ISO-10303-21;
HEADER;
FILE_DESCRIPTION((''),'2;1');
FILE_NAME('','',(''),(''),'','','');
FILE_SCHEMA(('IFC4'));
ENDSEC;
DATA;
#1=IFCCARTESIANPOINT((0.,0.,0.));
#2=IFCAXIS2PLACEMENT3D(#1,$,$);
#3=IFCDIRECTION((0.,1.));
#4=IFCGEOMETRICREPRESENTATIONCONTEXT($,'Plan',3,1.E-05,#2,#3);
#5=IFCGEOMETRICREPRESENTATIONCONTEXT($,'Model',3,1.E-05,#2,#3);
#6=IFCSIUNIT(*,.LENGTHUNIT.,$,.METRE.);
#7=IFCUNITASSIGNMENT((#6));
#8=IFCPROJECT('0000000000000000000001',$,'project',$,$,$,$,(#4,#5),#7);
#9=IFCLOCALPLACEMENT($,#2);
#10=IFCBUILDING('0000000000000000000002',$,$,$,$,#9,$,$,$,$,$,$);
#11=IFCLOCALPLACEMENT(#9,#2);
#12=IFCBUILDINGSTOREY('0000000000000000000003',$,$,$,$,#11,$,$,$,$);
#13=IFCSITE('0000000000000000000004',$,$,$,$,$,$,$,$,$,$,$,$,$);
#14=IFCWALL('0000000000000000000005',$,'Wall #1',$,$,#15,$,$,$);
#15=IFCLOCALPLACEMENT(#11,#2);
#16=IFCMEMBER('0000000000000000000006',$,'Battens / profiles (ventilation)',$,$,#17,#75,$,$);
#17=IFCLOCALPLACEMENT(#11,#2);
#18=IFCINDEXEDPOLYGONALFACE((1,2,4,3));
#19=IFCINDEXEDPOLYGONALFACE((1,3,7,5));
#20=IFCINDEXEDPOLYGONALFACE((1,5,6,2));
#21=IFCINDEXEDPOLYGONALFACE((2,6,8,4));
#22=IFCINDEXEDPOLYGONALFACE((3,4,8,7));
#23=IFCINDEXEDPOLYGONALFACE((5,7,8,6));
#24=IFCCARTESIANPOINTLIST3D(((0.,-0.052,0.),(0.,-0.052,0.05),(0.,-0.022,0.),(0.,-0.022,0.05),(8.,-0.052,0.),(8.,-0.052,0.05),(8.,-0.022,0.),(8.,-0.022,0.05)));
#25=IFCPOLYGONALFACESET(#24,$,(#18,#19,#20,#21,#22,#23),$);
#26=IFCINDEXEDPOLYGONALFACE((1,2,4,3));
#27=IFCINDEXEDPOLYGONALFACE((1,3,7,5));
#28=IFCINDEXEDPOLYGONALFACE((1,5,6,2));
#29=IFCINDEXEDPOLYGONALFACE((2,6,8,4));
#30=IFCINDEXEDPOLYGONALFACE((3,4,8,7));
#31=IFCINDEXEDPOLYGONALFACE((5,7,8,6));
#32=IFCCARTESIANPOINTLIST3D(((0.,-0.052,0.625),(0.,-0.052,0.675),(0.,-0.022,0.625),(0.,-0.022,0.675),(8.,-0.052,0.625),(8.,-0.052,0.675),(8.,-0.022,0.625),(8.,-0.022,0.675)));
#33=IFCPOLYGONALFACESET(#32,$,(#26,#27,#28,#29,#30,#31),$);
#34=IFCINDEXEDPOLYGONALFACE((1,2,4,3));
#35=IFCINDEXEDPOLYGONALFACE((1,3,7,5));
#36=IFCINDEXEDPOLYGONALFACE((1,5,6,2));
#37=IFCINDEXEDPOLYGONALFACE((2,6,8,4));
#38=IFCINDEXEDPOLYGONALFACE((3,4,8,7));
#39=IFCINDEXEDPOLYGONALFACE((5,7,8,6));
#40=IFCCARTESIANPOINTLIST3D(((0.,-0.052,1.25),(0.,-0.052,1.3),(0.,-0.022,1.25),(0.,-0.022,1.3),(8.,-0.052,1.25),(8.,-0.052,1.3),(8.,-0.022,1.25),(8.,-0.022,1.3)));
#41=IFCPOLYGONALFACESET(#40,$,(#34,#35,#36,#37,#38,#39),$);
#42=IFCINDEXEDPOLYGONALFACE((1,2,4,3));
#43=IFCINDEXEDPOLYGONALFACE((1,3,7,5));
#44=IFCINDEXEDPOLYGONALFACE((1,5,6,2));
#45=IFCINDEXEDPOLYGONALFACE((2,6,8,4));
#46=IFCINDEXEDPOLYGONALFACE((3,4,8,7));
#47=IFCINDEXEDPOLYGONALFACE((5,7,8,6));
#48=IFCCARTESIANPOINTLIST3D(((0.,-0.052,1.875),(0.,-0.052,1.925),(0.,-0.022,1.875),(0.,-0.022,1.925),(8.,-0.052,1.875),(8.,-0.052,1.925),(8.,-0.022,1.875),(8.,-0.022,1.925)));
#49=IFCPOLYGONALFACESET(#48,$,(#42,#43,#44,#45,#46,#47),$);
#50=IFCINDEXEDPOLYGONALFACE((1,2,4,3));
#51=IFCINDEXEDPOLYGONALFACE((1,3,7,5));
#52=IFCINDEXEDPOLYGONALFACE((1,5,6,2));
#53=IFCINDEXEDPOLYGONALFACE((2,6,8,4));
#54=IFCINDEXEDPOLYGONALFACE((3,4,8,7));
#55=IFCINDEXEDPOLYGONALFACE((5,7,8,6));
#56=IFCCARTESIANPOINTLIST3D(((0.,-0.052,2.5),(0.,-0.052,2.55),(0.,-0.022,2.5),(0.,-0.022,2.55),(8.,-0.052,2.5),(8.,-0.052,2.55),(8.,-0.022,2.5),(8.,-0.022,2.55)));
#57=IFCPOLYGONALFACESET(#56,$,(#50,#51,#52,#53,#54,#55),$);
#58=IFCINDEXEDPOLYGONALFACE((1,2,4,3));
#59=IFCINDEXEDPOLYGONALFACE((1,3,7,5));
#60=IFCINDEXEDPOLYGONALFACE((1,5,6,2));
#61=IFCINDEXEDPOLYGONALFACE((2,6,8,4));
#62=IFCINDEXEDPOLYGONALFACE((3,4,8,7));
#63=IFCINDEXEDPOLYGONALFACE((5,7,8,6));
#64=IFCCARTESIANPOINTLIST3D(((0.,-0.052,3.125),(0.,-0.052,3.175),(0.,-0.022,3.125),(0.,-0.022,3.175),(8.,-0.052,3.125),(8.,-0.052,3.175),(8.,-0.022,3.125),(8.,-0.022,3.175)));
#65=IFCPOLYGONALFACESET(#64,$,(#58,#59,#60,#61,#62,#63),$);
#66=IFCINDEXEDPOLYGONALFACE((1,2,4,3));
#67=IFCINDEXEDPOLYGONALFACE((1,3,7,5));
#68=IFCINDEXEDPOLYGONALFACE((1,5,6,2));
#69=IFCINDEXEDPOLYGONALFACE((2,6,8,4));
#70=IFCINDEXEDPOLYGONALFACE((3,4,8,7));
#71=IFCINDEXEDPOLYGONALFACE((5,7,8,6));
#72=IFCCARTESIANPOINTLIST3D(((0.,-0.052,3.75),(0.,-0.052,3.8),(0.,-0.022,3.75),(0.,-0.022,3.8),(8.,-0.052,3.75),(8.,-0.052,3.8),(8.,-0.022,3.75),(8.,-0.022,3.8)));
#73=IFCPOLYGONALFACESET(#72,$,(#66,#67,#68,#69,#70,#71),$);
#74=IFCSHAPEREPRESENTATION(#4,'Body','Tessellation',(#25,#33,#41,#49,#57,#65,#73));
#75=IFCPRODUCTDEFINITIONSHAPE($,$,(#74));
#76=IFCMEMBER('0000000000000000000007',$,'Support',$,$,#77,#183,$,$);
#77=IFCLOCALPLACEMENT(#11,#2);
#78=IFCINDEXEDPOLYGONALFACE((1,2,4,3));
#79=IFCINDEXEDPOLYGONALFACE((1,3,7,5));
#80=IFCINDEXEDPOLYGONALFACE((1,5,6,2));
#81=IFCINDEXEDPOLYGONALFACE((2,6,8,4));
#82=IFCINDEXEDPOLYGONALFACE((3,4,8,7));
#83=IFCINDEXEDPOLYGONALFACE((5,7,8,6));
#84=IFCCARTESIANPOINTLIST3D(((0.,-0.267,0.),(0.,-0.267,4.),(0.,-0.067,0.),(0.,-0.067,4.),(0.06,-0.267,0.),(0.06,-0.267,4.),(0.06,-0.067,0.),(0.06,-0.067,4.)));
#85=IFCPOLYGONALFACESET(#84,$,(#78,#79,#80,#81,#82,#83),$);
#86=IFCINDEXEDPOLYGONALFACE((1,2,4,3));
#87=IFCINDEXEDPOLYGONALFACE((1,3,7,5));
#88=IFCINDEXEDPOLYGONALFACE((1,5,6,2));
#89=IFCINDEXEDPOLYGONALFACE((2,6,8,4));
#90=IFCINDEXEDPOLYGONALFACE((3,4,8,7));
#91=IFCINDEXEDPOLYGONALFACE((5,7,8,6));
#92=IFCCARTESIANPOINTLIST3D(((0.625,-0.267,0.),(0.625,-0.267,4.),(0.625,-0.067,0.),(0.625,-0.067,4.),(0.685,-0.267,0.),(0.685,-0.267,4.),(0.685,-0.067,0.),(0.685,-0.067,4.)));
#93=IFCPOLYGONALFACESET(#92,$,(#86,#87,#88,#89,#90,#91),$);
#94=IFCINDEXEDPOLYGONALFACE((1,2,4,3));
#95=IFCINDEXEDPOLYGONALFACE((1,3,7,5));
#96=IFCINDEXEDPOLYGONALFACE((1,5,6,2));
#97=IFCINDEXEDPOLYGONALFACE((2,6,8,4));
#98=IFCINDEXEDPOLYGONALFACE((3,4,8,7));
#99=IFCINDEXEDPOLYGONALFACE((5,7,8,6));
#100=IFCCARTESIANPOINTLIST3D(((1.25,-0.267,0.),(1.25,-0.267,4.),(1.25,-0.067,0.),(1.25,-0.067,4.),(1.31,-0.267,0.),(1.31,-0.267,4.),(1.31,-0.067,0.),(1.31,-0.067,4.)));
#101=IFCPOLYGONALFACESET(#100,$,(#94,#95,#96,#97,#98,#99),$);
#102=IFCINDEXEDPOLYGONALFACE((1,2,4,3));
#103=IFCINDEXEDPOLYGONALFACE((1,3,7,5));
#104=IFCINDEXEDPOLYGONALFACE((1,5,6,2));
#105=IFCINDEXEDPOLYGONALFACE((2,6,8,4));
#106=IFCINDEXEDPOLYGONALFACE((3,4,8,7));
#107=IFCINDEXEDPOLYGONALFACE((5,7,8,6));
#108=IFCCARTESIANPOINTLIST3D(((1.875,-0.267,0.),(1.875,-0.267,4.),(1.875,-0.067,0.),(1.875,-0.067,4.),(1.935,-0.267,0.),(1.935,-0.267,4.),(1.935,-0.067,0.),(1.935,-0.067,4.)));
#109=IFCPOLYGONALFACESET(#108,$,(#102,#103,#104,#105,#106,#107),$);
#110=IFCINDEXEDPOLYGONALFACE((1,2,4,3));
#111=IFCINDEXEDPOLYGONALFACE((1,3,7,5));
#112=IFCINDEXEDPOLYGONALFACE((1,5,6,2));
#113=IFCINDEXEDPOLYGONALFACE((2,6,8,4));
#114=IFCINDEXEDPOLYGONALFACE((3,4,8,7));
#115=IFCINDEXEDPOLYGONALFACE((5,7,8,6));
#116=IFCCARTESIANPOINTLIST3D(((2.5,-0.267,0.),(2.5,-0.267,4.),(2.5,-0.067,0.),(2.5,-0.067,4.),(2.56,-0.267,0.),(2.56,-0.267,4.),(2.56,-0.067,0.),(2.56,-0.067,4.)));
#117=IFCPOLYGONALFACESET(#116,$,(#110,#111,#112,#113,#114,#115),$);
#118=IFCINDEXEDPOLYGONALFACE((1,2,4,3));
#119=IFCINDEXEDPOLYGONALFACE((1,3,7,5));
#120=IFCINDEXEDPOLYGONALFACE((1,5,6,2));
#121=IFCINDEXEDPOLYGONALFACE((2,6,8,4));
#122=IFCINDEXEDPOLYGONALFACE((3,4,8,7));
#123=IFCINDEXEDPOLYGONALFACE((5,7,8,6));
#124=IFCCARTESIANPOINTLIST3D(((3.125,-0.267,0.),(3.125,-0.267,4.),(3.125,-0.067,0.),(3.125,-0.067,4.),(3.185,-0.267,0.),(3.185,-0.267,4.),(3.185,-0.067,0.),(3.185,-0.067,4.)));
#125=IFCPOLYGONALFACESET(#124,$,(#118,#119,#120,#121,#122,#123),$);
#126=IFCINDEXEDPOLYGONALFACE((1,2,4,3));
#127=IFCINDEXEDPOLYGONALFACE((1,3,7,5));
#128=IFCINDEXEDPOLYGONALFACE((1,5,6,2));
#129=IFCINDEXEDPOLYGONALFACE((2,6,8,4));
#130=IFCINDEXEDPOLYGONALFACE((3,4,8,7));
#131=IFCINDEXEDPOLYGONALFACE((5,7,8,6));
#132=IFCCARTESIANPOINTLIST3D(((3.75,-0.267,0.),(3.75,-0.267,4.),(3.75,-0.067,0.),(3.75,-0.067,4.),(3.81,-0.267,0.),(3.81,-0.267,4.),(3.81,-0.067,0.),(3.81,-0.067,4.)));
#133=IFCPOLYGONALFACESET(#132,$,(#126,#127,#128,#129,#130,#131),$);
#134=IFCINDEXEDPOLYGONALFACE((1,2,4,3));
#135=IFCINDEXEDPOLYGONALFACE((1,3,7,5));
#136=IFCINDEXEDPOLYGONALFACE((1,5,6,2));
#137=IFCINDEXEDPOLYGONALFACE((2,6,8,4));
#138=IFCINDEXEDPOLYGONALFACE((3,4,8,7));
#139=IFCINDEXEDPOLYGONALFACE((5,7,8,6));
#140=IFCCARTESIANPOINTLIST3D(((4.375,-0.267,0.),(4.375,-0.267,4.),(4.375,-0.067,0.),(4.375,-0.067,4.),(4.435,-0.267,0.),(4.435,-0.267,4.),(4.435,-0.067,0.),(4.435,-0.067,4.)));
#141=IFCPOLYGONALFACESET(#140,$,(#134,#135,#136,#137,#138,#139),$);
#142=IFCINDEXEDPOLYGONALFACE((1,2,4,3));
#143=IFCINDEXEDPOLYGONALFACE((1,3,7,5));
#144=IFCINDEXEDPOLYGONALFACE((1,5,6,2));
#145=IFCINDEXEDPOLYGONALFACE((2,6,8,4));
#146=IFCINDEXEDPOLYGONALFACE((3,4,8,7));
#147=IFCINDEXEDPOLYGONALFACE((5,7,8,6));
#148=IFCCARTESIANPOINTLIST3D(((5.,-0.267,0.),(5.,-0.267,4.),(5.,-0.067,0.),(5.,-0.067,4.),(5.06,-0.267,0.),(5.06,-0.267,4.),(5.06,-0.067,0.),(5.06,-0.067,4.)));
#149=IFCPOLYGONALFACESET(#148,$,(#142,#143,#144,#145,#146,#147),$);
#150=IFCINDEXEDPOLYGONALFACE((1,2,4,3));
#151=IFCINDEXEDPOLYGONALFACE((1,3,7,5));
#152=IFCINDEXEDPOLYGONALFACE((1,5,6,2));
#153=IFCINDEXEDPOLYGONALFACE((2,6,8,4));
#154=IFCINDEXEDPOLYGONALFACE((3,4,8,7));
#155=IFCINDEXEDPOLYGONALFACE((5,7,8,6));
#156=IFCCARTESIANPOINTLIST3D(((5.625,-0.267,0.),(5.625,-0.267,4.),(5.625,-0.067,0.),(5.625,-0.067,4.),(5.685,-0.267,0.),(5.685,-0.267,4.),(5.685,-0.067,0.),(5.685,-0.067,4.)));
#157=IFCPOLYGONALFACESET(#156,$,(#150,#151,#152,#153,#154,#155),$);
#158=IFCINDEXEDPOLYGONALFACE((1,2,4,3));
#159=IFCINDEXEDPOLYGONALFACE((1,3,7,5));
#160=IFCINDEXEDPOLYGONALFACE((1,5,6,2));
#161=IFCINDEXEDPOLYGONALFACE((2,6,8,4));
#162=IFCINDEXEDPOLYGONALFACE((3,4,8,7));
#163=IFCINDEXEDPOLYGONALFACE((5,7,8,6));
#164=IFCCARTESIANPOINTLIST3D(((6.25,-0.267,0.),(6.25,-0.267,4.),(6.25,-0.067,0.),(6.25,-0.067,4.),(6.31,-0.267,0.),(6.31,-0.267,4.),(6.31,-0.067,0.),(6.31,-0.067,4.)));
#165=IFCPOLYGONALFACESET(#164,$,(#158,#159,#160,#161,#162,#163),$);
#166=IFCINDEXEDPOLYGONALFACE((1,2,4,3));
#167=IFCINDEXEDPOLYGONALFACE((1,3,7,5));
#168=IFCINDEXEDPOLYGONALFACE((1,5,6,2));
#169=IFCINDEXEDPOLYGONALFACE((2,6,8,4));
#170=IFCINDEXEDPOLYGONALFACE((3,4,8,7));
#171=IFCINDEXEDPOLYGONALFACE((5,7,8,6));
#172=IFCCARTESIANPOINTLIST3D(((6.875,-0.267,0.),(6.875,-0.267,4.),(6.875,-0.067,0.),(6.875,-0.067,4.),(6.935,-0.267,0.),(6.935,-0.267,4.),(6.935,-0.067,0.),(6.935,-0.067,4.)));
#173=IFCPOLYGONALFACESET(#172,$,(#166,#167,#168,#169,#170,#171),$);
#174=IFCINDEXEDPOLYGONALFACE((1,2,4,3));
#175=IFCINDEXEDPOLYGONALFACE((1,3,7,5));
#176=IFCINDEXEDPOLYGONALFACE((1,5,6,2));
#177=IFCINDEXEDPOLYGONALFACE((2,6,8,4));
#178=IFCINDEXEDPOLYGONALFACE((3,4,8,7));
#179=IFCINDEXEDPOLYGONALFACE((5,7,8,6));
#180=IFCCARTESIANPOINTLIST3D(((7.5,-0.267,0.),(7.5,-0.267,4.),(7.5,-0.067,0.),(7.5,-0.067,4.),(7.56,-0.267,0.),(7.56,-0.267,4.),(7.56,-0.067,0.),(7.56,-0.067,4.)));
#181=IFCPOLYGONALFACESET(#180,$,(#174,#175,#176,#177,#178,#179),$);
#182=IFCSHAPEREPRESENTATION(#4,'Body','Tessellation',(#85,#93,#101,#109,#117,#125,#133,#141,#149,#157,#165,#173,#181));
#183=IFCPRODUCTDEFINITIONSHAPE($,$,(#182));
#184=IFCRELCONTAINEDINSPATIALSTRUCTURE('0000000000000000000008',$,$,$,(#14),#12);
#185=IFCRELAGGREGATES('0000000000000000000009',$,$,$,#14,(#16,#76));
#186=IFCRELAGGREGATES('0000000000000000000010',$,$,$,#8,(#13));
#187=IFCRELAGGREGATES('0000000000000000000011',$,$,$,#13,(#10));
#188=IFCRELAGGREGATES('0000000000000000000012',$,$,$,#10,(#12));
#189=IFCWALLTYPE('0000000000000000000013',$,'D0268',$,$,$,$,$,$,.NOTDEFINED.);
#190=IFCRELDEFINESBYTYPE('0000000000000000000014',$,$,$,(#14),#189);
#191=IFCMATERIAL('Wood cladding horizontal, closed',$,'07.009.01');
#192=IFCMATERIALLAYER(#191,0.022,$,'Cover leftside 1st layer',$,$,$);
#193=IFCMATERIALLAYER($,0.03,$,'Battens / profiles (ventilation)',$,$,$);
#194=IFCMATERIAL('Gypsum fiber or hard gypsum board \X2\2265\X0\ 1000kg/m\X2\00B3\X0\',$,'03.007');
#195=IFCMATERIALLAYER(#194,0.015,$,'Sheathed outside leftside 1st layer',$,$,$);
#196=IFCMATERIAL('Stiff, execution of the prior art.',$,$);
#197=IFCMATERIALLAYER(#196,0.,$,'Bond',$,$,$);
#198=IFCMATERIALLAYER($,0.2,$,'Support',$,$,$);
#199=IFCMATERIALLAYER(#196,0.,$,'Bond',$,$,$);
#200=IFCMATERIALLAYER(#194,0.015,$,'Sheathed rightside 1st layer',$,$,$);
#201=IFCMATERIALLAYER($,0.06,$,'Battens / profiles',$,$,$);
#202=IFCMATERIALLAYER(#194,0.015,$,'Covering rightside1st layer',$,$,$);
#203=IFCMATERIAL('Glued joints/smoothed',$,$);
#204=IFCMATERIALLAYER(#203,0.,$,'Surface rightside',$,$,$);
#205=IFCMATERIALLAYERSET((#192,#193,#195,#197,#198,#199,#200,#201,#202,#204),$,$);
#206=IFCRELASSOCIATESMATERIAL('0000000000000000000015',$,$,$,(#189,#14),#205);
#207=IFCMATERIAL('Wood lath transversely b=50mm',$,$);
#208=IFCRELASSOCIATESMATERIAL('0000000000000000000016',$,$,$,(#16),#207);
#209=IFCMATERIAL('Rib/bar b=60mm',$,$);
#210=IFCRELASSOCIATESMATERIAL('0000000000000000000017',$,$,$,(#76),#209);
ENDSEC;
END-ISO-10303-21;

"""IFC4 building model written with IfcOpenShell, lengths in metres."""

from ifc_helpers import new_model, si_unit, direction, frame, frame_2d, origin, place, context, project, spatial, rectangle, extrude, material, layer, layer_set, type_object, element, aggregate, save


model = new_model("IFC4")

# Units and contexts
plan_context = context("Plan", 3, precision=1e-05, world=origin(), true_north=direction((0.0, 1.0)))
model_context = context("Model", 3, precision=1e-05, world=origin(), true_north=direction((0.0, 1.0)))
ifc_project = project(units=[si_unit("LENGTHUNIT", "METRE")], contexts=[plan_context, model_context])

# Site, building, storey
site = spatial("IfcSite", under=ifc_project)
building_placement = place(None, origin())
building = spatial("IfcBuilding", under=site, at=building_placement)
storey_placement = place(building_placement, origin())
storey = spatial("IfcBuildingStorey", under=building, at=storey_placement)

# Wall, members
ifc_material_1 = material(Name="Wood cladding horizontal, closed", Category="07.009.01")
ifc_layer_1 = layer(ifc_material_1, 0.022, Name="Cover leftside 1st layer")
ifc_layer_2 = layer(None, 0.03, Name="Battens / profiles (ventilation)")
ifc_material_2 = material(Name="Gypsum fiber or hard gypsum board ≥ 1000kg/m³", Category="03.007")
ifc_layer_3 = layer(ifc_material_2, 0.015, Name="Sheathed outside leftside 1st layer")
ifc_material_3 = material(Name="Stiff, execution of the prior art.")
ifc_layer_4 = layer(ifc_material_3, 0.0, Name="Bond")
ifc_layer_5 = layer(None, 0.2, Name="Support")
ifc_layer_6 = layer(ifc_material_3, 0.0, Name="Bond")
ifc_layer_7 = layer(ifc_material_2, 0.015, Name="Sheathed rightside 1st layer")
ifc_layer_8 = layer(None, 0.06, Name="Battens / profiles")
ifc_layer_9 = layer(ifc_material_2, 0.015, Name="Covering rightside1st layer")
ifc_material_4 = material(Name="Glued joints/smoothed")
ifc_layer_10 = layer(ifc_material_4, 0.0, Name="Surface rightside")
ifc_layer_set = layer_set([ifc_layer_1, ifc_layer_2, ifc_layer_3, ifc_layer_4, ifc_layer_5, ifc_layer_6, ifc_layer_7, ifc_layer_8, ifc_layer_9, ifc_layer_10])
wall_type = type_object("IfcWallType", Name="D0268", PredefinedType="NOTDEFINED", material=ifc_layer_set)
wall_placement = place(None, frame((0.0, 0.0, 0.0), z_axis=(0.0, -1.0, 0.0), x_axis=(1.0, 0.0, 0.0)))
wall = element("IfcWall", 1, at=wall_placement, inside=storey, type_object=wall_type, material=ifc_layer_set, Name="Wall #1")
ifc_material_5 = material(Name="Wood lath transversely b=50mm")
member_1_placement = place(wall_placement, origin())
member_1 = element("IfcMember", 2, at=member_1_placement, material=ifc_material_5, Name="Battens / profiles (ventilation)", context=plan_context, shape_type="SweptSolid", body=[
    extrude(rectangle(XDim=0.05, YDim=0.03, at=frame_2d((0.025, 0.015), x_axis=(1.0, 0.0))), frame((0.0, 0.0, 0.022), z_axis=(1.0, 0.0, 0.0), x_axis=(0.0, 1.0, 0.0)), (0.0, 0.0, 1.0), 8.0),
    extrude(rectangle(XDim=0.05, YDim=0.03, at=frame_2d((0.025, 0.015), x_axis=(1.0, 0.0))), frame((0.0, 0.625, 0.022), z_axis=(1.0, 0.0, 0.0), x_axis=(0.0, 1.0, 0.0)), (0.0, 0.0, 1.0), 8.0),
    extrude(rectangle(XDim=0.05, YDim=0.03, at=frame_2d((0.025, 0.015), x_axis=(1.0, 0.0))), frame((0.0, 1.25, 0.022), z_axis=(1.0, 0.0, 0.0), x_axis=(0.0, 1.0, 0.0)), (0.0, 0.0, 1.0), 8.0),
    extrude(rectangle(XDim=0.05, YDim=0.03, at=frame_2d((0.025, 0.015), x_axis=(1.0, 0.0))), frame((0.0, 1.875, 0.022), z_axis=(1.0, 0.0, 0.0), x_axis=(0.0, 1.0, 0.0)), (0.0, 0.0, 1.0), 8.0),
    extrude(rectangle(XDim=0.05, YDim=0.03, at=frame_2d((0.025, 0.015), x_axis=(1.0, 0.0))), frame((0.0, 2.5, 0.022), z_axis=(1.0, 0.0, 0.0), x_axis=(0.0, 1.0, 0.0)), (0.0, 0.0, 1.0), 8.0),
    extrude(rectangle(XDim=0.05, YDim=0.03, at=frame_2d((0.025, 0.015), x_axis=(1.0, 0.0))), frame((0.0, 3.125, 0.022), z_axis=(1.0, 0.0, 0.0), x_axis=(0.0, 1.0, 0.0)), (0.0, 0.0, 1.0), 8.0),
    extrude(rectangle(XDim=0.05, YDim=0.03, at=frame_2d((0.025, 0.015), x_axis=(1.0, 0.0))), frame((0.0, 3.75, 0.022), z_axis=(1.0, 0.0, 0.0), x_axis=(0.0, 1.0, 0.0)), (0.0, 0.0, 1.0), 8.0),
])
ifc_material_6 = material(Name="Rib/bar b=60mm")
member_2_placement = place(wall_placement, origin())
member_2 = element("IfcMember", 3, at=member_2_placement, material=ifc_material_6, Name="Support", context=plan_context, shape_type="SweptSolid", body=[
    extrude(rectangle(XDim=0.06, YDim=0.2, at=frame_2d((0.03, 0.1), x_axis=(1.0, 0.0))), frame((0.0, 4.0, 0.067), z_axis=(0.0, -1.0, 0.0), x_axis=(1.0, 0.0, 0.0)), (0.0, 0.0, 1.0), 4.0),
    extrude(rectangle(XDim=0.06, YDim=0.2, at=frame_2d((0.03, 0.1), x_axis=(1.0, 0.0))), frame((0.625, 4.0, 0.067), z_axis=(0.0, -1.0, 0.0), x_axis=(1.0, 0.0, 0.0)), (0.0, 0.0, 1.0), 4.0),
    extrude(rectangle(XDim=0.06, YDim=0.2, at=frame_2d((0.03, 0.1), x_axis=(1.0, 0.0))), frame((1.25, 4.0, 0.067), z_axis=(0.0, -1.0, 0.0), x_axis=(1.0, 0.0, 0.0)), (0.0, 0.0, 1.0), 4.0),
    extrude(rectangle(XDim=0.06, YDim=0.2, at=frame_2d((0.03, 0.1), x_axis=(1.0, 0.0))), frame((1.875, 4.0, 0.067), z_axis=(0.0, -1.0, 0.0), x_axis=(1.0, 0.0, 0.0)), (0.0, 0.0, 1.0), 4.0),
    extrude(rectangle(XDim=0.06, YDim=0.2, at=frame_2d((0.03, 0.1), x_axis=(1.0, 0.0))), frame((2.5, 4.0, 0.067), z_axis=(0.0, -1.0, 0.0), x_axis=(1.0, 0.0, 0.0)), (0.0, 0.0, 1.0), 4.0),
    extrude(rectangle(XDim=0.06, YDim=0.2, at=frame_2d((0.03, 0.1), x_axis=(1.0, 0.0))), frame((3.125, 4.0, 0.067), z_axis=(0.0, -1.0, 0.0), x_axis=(1.0, 0.0, 0.0)), (0.0, 0.0, 1.0), 4.0),
    extrude(rectangle(XDim=0.06, YDim=0.2, at=frame_2d((0.03, 0.1), x_axis=(1.0, 0.0))), frame((3.75, 4.0, 0.067), z_axis=(0.0, -1.0, 0.0), x_axis=(1.0, 0.0, 0.0)), (0.0, 0.0, 1.0), 4.0),
    extrude(rectangle(XDim=0.06, YDim=0.2, at=frame_2d((0.03, 0.1), x_axis=(1.0, 0.0))), frame((4.375, 4.0, 0.067), z_axis=(0.0, -1.0, 0.0), x_axis=(1.0, 0.0, 0.0)), (0.0, 0.0, 1.0), 4.0),
    extrude(rectangle(XDim=0.06, YDim=0.2, at=frame_2d((0.03, 0.1), x_axis=(1.0, 0.0))), frame((5.0, 4.0, 0.067), z_axis=(0.0, -1.0, 0.0), x_axis=(1.0, 0.0, 0.0)), (0.0, 0.0, 1.0), 4.0),
    extrude(rectangle(XDim=0.06, YDim=0.2, at=frame_2d((0.03, 0.1), x_axis=(1.0, 0.0))), frame((5.625, 4.0, 0.067), z_axis=(0.0, -1.0, 0.0), x_axis=(1.0, 0.0, 0.0)), (0.0, 0.0, 1.0), 4.0),
    extrude(rectangle(XDim=0.06, YDim=0.2, at=frame_2d((0.03, 0.1), x_axis=(1.0, 0.0))), frame((6.25, 4.0, 0.067), z_axis=(0.0, -1.0, 0.0), x_axis=(1.0, 0.0, 0.0)), (0.0, 0.0, 1.0), 4.0),
    extrude(rectangle(XDim=0.06, YDim=0.2, at=frame_2d((0.03, 0.1), x_axis=(1.0, 0.0))), frame((6.875, 4.0, 0.067), z_axis=(0.0, -1.0, 0.0), x_axis=(1.0, 0.0, 0.0)), (0.0, 0.0, 1.0), 4.0),
    extrude(rectangle(XDim=0.06, YDim=0.2, at=frame_2d((0.03, 0.1), x_axis=(1.0, 0.0))), frame((7.5, 4.0, 0.067), z_axis=(0.0, -1.0, 0.0), x_axis=(1.0, 0.0, 0.0)), (0.0, 0.0, 1.0), 4.0),
])
aggregate(wall, [member_1, member_2])

save(model, "model.ifc")
